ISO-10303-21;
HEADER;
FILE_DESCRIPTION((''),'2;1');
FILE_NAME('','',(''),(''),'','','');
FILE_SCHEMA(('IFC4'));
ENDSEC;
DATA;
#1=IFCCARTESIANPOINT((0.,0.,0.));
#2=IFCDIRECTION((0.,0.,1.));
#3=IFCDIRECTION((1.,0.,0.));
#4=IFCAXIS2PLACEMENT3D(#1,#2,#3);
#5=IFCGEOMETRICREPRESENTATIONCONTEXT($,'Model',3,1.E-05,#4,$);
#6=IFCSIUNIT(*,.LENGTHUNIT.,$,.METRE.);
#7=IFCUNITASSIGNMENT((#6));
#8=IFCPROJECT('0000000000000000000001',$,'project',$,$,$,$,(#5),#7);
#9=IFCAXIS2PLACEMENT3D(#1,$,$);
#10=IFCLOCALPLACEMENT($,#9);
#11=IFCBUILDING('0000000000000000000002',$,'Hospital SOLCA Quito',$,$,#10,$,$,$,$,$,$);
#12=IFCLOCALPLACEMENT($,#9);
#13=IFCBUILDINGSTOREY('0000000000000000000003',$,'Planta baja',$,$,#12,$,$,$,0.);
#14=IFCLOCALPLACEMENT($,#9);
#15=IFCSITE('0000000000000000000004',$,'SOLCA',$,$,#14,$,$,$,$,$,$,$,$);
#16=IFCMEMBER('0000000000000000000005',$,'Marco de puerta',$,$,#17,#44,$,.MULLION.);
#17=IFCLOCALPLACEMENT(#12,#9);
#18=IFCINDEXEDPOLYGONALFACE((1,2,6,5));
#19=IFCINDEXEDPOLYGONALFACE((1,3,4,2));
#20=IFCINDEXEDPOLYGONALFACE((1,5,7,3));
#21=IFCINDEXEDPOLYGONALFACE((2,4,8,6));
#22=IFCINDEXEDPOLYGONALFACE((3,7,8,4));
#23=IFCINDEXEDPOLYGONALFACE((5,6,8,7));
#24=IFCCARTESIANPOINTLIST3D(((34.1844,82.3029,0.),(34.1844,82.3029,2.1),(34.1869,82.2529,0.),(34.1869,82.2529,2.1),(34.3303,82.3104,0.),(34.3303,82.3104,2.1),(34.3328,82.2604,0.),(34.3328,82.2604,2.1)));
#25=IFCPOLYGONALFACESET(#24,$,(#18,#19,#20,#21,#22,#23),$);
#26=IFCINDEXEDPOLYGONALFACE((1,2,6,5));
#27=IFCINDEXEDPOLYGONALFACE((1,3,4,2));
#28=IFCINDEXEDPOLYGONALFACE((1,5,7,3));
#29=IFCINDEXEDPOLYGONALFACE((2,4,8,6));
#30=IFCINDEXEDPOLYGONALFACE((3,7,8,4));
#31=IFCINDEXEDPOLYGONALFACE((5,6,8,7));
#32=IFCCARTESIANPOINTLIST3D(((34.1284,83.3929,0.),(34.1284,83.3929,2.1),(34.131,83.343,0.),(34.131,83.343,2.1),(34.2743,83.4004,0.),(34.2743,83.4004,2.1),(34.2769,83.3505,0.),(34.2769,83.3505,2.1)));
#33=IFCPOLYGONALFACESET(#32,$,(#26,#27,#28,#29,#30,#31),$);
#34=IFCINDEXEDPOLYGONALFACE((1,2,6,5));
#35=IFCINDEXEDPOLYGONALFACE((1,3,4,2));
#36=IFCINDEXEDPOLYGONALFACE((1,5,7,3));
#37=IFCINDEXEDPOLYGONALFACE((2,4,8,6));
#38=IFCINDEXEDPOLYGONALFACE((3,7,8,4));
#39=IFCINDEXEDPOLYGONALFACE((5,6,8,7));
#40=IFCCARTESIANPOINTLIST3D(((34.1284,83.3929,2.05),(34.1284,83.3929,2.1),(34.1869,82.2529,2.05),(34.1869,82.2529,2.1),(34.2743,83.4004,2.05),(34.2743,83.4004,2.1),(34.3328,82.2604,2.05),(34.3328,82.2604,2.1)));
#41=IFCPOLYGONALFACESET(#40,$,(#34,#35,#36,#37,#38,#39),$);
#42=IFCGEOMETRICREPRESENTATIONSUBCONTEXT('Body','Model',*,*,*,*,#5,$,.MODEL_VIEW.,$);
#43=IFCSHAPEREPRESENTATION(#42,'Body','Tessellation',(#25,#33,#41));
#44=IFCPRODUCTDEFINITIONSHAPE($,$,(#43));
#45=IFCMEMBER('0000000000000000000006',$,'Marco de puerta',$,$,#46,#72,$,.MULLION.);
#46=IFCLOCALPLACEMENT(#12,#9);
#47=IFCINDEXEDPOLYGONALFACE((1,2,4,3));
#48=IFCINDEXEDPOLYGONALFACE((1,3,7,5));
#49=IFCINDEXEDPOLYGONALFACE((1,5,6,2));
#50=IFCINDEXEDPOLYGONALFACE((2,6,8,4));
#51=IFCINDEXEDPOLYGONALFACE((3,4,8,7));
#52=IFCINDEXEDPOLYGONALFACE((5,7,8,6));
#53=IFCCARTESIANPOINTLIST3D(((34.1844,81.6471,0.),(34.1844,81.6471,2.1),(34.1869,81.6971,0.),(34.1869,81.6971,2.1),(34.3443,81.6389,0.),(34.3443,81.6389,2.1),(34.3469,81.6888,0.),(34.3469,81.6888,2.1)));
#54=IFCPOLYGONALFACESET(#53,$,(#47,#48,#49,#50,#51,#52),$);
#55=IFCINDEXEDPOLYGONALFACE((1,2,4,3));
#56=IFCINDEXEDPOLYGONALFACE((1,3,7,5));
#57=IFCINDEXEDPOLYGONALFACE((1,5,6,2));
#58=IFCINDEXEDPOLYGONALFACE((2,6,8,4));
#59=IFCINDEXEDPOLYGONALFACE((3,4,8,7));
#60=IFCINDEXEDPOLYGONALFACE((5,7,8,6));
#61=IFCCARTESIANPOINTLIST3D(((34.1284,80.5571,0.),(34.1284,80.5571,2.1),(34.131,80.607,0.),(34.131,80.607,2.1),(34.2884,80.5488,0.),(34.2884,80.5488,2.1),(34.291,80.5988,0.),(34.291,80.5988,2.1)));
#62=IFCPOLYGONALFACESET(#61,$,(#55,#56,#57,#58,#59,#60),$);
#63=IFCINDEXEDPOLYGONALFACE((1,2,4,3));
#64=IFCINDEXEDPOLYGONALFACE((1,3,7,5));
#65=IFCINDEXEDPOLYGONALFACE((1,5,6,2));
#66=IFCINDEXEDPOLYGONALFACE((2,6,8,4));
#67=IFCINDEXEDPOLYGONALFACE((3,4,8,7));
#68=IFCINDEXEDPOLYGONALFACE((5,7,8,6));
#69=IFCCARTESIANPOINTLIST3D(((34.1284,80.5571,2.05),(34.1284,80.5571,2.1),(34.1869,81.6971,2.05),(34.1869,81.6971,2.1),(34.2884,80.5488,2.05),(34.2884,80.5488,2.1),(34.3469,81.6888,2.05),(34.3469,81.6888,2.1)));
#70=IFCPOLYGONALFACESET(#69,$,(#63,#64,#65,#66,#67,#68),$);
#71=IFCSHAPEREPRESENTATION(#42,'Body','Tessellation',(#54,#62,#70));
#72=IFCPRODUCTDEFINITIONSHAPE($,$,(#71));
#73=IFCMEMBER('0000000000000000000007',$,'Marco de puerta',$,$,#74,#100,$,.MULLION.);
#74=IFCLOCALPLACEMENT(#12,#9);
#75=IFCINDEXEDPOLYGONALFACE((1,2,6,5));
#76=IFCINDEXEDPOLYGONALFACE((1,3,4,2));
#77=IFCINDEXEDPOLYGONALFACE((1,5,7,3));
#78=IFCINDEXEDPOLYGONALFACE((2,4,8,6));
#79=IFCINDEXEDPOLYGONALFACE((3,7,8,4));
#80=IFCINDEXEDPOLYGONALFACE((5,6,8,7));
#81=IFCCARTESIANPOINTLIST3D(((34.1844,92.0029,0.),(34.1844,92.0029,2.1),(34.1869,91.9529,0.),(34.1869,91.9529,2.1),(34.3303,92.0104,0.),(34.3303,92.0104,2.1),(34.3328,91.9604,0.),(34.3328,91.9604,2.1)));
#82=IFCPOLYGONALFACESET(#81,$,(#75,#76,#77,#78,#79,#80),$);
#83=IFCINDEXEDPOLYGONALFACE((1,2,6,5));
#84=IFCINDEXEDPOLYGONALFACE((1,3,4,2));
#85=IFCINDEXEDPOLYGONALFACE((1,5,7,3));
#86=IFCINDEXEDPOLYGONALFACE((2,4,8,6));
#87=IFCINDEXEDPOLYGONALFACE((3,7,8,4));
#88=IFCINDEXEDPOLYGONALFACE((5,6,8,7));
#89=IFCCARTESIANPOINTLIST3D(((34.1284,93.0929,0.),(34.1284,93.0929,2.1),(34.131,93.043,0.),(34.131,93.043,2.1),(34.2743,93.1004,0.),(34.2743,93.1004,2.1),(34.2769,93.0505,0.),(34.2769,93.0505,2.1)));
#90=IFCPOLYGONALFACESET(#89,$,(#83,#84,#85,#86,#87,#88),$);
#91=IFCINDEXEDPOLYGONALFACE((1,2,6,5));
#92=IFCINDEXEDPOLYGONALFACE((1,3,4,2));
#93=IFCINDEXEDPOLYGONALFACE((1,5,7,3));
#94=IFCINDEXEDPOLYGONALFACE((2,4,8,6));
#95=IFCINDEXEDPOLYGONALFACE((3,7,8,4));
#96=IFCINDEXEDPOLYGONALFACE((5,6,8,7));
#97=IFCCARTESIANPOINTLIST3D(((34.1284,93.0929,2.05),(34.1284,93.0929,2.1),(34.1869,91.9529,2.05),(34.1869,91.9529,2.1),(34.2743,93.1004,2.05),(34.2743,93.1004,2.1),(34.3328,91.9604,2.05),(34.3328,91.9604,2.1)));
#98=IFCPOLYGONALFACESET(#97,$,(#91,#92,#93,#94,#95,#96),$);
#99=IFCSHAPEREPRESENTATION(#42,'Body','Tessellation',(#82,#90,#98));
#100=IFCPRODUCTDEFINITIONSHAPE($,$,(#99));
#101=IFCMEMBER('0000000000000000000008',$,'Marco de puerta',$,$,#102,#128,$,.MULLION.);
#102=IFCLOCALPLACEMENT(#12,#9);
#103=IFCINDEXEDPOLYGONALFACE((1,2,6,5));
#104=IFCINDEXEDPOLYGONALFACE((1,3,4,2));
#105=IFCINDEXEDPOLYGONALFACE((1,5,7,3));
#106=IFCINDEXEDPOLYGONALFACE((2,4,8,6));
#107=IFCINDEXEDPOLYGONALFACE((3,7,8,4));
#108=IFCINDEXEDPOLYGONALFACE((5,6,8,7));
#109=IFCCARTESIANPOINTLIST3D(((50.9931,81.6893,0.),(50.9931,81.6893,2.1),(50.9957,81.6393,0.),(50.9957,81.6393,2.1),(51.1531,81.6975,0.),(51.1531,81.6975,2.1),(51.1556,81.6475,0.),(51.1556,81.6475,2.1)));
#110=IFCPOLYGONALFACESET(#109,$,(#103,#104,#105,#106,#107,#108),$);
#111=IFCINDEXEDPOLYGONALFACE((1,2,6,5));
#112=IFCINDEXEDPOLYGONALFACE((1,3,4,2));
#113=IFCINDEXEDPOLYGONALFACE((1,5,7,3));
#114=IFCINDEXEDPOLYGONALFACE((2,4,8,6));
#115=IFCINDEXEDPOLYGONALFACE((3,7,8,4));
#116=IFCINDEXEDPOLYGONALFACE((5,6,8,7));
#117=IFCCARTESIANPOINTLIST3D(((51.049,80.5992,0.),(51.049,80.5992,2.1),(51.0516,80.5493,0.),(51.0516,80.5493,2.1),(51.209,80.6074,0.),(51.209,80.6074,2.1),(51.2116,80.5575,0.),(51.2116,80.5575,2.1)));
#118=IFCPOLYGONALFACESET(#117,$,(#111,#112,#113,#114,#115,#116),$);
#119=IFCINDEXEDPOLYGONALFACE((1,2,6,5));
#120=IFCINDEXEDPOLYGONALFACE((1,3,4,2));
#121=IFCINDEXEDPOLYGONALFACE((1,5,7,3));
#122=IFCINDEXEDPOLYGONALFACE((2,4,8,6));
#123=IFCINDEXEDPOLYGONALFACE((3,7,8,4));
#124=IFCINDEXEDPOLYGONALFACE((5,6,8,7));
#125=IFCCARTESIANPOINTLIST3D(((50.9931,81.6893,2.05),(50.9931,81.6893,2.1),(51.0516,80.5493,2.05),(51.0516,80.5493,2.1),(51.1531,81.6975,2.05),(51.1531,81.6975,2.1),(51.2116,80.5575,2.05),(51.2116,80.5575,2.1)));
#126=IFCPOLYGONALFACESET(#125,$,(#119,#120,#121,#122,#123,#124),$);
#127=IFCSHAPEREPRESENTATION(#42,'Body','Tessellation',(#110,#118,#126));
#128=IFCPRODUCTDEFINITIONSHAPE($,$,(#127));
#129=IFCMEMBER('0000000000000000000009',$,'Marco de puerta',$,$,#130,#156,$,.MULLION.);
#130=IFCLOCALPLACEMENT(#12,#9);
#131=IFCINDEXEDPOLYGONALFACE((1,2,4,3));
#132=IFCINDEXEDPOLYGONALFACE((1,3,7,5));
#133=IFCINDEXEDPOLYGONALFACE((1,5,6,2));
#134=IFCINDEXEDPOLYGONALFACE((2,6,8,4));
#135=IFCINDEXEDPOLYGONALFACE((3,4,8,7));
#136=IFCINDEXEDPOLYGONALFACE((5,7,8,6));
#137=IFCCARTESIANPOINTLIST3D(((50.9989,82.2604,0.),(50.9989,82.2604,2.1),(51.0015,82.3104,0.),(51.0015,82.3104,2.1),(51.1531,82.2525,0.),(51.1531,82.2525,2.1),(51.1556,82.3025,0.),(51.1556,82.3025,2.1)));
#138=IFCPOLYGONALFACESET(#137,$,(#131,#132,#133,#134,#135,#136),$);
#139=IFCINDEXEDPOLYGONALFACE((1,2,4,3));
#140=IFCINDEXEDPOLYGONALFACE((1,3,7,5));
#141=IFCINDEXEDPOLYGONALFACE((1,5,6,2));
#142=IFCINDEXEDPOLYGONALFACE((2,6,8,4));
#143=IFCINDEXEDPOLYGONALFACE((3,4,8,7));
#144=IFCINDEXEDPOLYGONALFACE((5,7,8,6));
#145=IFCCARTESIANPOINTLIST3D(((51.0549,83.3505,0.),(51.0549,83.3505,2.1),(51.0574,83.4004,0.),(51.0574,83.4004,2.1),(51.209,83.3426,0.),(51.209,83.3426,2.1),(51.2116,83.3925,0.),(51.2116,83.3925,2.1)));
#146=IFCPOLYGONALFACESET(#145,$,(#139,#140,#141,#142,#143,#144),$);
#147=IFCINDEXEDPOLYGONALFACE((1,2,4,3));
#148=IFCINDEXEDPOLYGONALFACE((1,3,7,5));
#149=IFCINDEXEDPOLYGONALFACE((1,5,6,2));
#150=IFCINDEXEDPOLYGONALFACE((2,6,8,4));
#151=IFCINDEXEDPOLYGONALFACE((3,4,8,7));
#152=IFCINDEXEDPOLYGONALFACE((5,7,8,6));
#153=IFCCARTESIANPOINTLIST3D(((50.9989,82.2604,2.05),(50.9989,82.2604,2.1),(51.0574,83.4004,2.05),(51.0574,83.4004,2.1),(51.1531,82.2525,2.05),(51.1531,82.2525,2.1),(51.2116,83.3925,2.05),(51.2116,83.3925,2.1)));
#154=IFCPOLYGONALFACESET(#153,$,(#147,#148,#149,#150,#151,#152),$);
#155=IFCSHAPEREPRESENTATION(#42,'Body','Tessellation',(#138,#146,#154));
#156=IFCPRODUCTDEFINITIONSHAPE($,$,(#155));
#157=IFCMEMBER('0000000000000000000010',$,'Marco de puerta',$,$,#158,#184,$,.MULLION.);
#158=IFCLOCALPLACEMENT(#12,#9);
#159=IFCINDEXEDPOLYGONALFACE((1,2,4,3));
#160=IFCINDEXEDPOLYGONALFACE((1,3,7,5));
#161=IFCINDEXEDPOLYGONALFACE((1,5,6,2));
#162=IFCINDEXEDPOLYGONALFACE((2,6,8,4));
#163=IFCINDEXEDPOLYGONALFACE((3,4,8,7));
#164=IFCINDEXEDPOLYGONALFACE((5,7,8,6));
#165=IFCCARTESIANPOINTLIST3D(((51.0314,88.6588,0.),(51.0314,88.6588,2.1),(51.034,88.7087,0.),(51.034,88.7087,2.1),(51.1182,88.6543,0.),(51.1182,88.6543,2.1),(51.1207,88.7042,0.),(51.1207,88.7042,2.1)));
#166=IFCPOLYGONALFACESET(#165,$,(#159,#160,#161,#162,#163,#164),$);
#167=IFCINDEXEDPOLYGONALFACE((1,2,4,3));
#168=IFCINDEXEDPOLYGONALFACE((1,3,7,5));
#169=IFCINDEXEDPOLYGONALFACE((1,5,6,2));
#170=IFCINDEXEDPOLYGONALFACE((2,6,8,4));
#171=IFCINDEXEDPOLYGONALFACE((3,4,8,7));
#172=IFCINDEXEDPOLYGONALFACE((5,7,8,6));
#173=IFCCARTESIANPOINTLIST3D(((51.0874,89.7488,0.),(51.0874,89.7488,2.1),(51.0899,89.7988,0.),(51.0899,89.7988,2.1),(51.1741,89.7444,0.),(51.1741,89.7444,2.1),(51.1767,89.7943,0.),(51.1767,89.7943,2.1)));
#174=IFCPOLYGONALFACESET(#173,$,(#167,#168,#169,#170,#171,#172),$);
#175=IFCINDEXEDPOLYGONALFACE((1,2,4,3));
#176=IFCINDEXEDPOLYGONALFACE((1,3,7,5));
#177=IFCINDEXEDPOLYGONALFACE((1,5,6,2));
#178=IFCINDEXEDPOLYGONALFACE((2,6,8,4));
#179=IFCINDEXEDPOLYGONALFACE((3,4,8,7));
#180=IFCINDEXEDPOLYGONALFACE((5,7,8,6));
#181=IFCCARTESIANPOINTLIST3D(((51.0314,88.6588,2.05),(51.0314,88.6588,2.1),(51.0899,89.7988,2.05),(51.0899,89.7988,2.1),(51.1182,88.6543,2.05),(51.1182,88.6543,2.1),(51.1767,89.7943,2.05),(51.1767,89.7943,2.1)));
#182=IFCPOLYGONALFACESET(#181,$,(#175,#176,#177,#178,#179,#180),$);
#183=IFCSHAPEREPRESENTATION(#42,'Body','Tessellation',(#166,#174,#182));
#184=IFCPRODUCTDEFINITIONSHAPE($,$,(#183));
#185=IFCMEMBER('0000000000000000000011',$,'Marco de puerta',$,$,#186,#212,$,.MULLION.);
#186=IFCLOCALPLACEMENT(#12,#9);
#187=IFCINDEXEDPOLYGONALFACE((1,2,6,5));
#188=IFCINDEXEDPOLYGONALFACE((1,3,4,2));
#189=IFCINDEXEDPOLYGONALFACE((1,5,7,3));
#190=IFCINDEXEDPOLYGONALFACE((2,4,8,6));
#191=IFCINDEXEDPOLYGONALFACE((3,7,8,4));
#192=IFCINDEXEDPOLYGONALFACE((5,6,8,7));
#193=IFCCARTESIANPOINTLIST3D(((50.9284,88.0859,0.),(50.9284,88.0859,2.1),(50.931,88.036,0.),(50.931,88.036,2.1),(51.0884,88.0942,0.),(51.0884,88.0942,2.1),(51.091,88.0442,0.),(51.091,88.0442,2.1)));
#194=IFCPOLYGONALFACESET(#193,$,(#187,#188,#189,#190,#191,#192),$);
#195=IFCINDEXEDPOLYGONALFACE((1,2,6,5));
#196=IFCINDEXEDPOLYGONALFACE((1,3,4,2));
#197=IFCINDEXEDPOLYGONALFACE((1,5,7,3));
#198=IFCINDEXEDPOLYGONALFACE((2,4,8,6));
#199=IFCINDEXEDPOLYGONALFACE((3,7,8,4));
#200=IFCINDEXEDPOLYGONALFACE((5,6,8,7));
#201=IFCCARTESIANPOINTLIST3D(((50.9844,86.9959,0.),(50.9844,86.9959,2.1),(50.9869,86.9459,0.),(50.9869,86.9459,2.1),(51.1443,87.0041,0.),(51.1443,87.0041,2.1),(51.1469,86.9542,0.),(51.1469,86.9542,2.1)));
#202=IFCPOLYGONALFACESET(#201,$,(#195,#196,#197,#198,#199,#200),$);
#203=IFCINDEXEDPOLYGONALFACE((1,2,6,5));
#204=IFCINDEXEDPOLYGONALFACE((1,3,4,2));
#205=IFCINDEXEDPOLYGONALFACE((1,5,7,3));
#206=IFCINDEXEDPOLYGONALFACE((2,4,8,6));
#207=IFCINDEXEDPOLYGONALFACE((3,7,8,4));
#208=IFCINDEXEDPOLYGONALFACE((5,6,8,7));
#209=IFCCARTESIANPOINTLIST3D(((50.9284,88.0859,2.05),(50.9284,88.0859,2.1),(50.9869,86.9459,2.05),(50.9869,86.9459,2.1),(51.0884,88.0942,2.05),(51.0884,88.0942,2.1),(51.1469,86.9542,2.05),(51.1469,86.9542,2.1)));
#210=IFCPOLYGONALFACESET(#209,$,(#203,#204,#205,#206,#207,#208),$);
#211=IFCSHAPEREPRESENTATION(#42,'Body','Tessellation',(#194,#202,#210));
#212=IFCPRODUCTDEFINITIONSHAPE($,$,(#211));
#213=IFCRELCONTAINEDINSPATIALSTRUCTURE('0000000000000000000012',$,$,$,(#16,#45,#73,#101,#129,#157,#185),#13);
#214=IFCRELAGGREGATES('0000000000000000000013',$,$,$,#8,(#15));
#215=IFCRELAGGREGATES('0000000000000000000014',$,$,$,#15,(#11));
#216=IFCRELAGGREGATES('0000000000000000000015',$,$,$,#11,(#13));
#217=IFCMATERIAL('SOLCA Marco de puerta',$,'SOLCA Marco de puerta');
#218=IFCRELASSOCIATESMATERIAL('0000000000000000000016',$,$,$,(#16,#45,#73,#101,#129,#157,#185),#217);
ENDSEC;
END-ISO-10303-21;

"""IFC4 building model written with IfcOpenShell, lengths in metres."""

from ifc_helpers import new_model, si_unit, frame, origin, origin_with_axes, place, context, subcontext, project, spatial, polyline, outline, extrude, material, element, save


model = new_model("IFC4")

# Units and contexts
model_context = context("Model", 3, precision=1e-05, world=origin_with_axes())
body_context = subcontext(model_context, "Body", "Model", "MODEL_VIEW")
ifc_project = project(units=[si_unit("LENGTHUNIT", "METRE")], contexts=[model_context])

# Site, building, storey
site_placement = place(None, origin())
site = spatial("IfcSite", under=ifc_project, at=site_placement, Name="SOLCA")
building_placement = place(None, origin())
building = spatial("IfcBuilding", under=site, at=building_placement, Name="Hospital SOLCA Quito")
storey_placement = place(None, origin())
storey = spatial("IfcBuildingStorey", under=building, at=storey_placement, Name="Planta baja", Elevation=0.0)

# Members
ifc_material_1 = material(Name="SOLCA Marco de puerta", Category="SOLCA Marco de puerta")
member_1_placement = place(storey_placement, origin_with_axes())
element("IfcMember", 1, at=member_1_placement, inside=storey, material=ifc_material_1, Name="Marco de puerta", PredefinedType="MULLION", context=body_context, shape_type="SweptSolid", body=[
    extrude(outline(polyline([(34.3328, 82.2604), (34.3303, 82.3104), (34.1844, 82.3029), (34.1869, 82.2529), (34.3328, 82.2604)])), origin_with_axes(), (0.0, 0.0, 1.0), 2.1),
    extrude(outline(polyline([(34.2769, 83.3505), (34.2743, 83.4004), (34.1284, 83.3929), (34.131, 83.343), (34.2769, 83.3505)])), origin_with_axes(), (0.0, 0.0, 1.0), 2.1),
    extrude(outline(polyline([(34.3328, 82.2604), (34.2743, 83.4004), (34.1284, 83.3929), (34.1869, 82.2529), (34.3328, 82.2604)])), frame((0.0, 0.0, 2.05), z_axis=(0.0, 0.0, 1.0), x_axis=(1.0, 0.0, 0.0)), (0.0, 0.0, 1.0), 0.05),
])
member_2_placement = place(storey_placement, origin_with_axes())
element("IfcMember", 2, at=member_2_placement, inside=storey, material=ifc_material_1, Name="Marco de puerta", PredefinedType="MULLION", context=body_context, shape_type="SweptSolid", body=[
    extrude(outline(polyline([(34.1869, 81.6971), (34.1844, 81.6471), (34.3443, 81.6389), (34.3469, 81.6888), (34.1869, 81.6971)])), origin_with_axes(), (0.0, 0.0, 1.0), 2.1),
    extrude(outline(polyline([(34.131, 80.607), (34.1284, 80.5571), (34.2884, 80.5488), (34.291, 80.5988), (34.131, 80.607)])), origin_with_axes(), (0.0, 0.0, 1.0), 2.1),
    extrude(outline(polyline([(34.1869, 81.6971), (34.1284, 80.5571), (34.2884, 80.5488), (34.3469, 81.6888), (34.1869, 81.6971)])), frame((0.0, 0.0, 2.05), z_axis=(0.0, 0.0, 1.0), x_axis=(1.0, 0.0, 0.0)), (0.0, 0.0, 1.0), 0.05),
])
member_3_placement = place(storey_placement, origin_with_axes())
element("IfcMember", 3, at=member_3_placement, inside=storey, material=ifc_material_1, Name="Marco de puerta", PredefinedType="MULLION", context=body_context, shape_type="SweptSolid", body=[
    extrude(outline(polyline([(34.3328, 91.9604), (34.3303, 92.0104), (34.1844, 92.0029), (34.1869, 91.9529), (34.3328, 91.9604)])), origin_with_axes(), (0.0, 0.0, 1.0), 2.1),
    extrude(outline(polyline([(34.2769, 93.0505), (34.2743, 93.1004), (34.1284, 93.0929), (34.131, 93.043), (34.2769, 93.0505)])), origin_with_axes(), (0.0, 0.0, 1.0), 2.1),
    extrude(outline(polyline([(34.3328, 91.9604), (34.2743, 93.1004), (34.1284, 93.0929), (34.1869, 91.9529), (34.3328, 91.9604)])), frame((0.0, 0.0, 2.05), z_axis=(0.0, 0.0, 1.0), x_axis=(1.0, 0.0, 0.0)), (0.0, 0.0, 1.0), 0.05),
])
member_4_placement = place(storey_placement, origin_with_axes())
element("IfcMember", 4, at=member_4_placement, inside=storey, material=ifc_material_1, Name="Marco de puerta", PredefinedType="MULLION", context=body_context, shape_type="SweptSolid", body=[
    extrude(outline(polyline([(50.9931, 81.6893), (50.9957, 81.6393), (51.1556, 81.6475), (51.1531, 81.6975), (50.9931, 81.6893)])), origin_with_axes(), (0.0, 0.0, 1.0), 2.1),
    extrude(outline(polyline([(51.049, 80.5992), (51.0516, 80.5493), (51.2116, 80.5575), (51.209, 80.6074), (51.049, 80.5992)])), origin_with_axes(), (0.0, 0.0, 1.0), 2.1),
    extrude(outline(polyline([(50.9931, 81.6893), (51.0516, 80.5493), (51.2116, 80.5575), (51.1531, 81.6975), (50.9931, 81.6893)])), frame((0.0, 0.0, 2.05), z_axis=(0.0, 0.0, 1.0), x_axis=(1.0, 0.0, 0.0)), (0.0, 0.0, 1.0), 0.05),
])
member_5_placement = place(storey_placement, origin_with_axes())
element("IfcMember", 5, at=member_5_placement, inside=storey, material=ifc_material_1, Name="Marco de puerta", PredefinedType="MULLION", context=body_context, shape_type="SweptSolid", body=[
    extrude(outline(polyline([(51.1531, 82.2525), (51.1556, 82.3025), (51.0015, 82.3104), (50.9989, 82.2604), (51.1531, 82.2525)])), origin_with_axes(), (0.0, 0.0, 1.0), 2.1),
    extrude(outline(polyline([(51.209, 83.3426), (51.2116, 83.3925), (51.0574, 83.4004), (51.0549, 83.3505), (51.209, 83.3426)])), origin_with_axes(), (0.0, 0.0, 1.0), 2.1),
    extrude(outline(polyline([(51.1531, 82.2525), (51.2116, 83.3925), (51.0574, 83.4004), (50.9989, 82.2604), (51.1531, 82.2525)])), frame((0.0, 0.0, 2.05), z_axis=(0.0, 0.0, 1.0), x_axis=(1.0, 0.0, 0.0)), (0.0, 0.0, 1.0), 0.05),
])
member_6_placement = place(storey_placement, origin_with_axes())
element("IfcMember", 6, at=member_6_placement, inside=storey, material=ifc_material_1, Name="Marco de puerta", PredefinedType="MULLION", context=body_context, shape_type="SweptSolid", body=[
    extrude(outline(polyline([(51.1182, 88.6543), (51.1207, 88.7042), (51.034, 88.7087), (51.0314, 88.6588), (51.1182, 88.6543)])), origin_with_axes(), (0.0, 0.0, 1.0), 2.1),
    extrude(outline(polyline([(51.1741, 89.7444), (51.1767, 89.7943), (51.0899, 89.7988), (51.0874, 89.7488), (51.1741, 89.7444)])), origin_with_axes(), (0.0, 0.0, 1.0), 2.1),
    extrude(outline(polyline([(51.1182, 88.6543), (51.1767, 89.7943), (51.0899, 89.7988), (51.0314, 88.6588), (51.1182, 88.6543)])), frame((0.0, 0.0, 2.05), z_axis=(0.0, 0.0, 1.0), x_axis=(1.0, 0.0, 0.0)), (0.0, 0.0, 1.0), 0.05),
])
member_7_placement = place(storey_placement, origin_with_axes())
element("IfcMember", 7, at=member_7_placement, inside=storey, material=ifc_material_1, Name="Marco de puerta", PredefinedType="MULLION", context=body_context, shape_type="SweptSolid", body=[
    extrude(outline(polyline([(50.9284, 88.0859), (50.931, 88.036), (51.091, 88.0442), (51.0884, 88.0942), (50.9284, 88.0859)])), origin_with_axes(), (0.0, 0.0, 1.0), 2.1),
    extrude(outline(polyline([(50.9844, 86.9959), (50.9869, 86.9459), (51.1469, 86.9542), (51.1443, 87.0041), (50.9844, 86.9959)])), origin_with_axes(), (0.0, 0.0, 1.0), 2.1),
    extrude(outline(polyline([(50.9284, 88.0859), (50.9869, 86.9459), (51.1469, 86.9542), (51.0884, 88.0942), (50.9284, 88.0859)])), frame((0.0, 0.0, 2.05), z_axis=(0.0, 0.0, 1.0), x_axis=(1.0, 0.0, 0.0)), (0.0, 0.0, 1.0), 0.05),
])

save(model, "model.ifc")
